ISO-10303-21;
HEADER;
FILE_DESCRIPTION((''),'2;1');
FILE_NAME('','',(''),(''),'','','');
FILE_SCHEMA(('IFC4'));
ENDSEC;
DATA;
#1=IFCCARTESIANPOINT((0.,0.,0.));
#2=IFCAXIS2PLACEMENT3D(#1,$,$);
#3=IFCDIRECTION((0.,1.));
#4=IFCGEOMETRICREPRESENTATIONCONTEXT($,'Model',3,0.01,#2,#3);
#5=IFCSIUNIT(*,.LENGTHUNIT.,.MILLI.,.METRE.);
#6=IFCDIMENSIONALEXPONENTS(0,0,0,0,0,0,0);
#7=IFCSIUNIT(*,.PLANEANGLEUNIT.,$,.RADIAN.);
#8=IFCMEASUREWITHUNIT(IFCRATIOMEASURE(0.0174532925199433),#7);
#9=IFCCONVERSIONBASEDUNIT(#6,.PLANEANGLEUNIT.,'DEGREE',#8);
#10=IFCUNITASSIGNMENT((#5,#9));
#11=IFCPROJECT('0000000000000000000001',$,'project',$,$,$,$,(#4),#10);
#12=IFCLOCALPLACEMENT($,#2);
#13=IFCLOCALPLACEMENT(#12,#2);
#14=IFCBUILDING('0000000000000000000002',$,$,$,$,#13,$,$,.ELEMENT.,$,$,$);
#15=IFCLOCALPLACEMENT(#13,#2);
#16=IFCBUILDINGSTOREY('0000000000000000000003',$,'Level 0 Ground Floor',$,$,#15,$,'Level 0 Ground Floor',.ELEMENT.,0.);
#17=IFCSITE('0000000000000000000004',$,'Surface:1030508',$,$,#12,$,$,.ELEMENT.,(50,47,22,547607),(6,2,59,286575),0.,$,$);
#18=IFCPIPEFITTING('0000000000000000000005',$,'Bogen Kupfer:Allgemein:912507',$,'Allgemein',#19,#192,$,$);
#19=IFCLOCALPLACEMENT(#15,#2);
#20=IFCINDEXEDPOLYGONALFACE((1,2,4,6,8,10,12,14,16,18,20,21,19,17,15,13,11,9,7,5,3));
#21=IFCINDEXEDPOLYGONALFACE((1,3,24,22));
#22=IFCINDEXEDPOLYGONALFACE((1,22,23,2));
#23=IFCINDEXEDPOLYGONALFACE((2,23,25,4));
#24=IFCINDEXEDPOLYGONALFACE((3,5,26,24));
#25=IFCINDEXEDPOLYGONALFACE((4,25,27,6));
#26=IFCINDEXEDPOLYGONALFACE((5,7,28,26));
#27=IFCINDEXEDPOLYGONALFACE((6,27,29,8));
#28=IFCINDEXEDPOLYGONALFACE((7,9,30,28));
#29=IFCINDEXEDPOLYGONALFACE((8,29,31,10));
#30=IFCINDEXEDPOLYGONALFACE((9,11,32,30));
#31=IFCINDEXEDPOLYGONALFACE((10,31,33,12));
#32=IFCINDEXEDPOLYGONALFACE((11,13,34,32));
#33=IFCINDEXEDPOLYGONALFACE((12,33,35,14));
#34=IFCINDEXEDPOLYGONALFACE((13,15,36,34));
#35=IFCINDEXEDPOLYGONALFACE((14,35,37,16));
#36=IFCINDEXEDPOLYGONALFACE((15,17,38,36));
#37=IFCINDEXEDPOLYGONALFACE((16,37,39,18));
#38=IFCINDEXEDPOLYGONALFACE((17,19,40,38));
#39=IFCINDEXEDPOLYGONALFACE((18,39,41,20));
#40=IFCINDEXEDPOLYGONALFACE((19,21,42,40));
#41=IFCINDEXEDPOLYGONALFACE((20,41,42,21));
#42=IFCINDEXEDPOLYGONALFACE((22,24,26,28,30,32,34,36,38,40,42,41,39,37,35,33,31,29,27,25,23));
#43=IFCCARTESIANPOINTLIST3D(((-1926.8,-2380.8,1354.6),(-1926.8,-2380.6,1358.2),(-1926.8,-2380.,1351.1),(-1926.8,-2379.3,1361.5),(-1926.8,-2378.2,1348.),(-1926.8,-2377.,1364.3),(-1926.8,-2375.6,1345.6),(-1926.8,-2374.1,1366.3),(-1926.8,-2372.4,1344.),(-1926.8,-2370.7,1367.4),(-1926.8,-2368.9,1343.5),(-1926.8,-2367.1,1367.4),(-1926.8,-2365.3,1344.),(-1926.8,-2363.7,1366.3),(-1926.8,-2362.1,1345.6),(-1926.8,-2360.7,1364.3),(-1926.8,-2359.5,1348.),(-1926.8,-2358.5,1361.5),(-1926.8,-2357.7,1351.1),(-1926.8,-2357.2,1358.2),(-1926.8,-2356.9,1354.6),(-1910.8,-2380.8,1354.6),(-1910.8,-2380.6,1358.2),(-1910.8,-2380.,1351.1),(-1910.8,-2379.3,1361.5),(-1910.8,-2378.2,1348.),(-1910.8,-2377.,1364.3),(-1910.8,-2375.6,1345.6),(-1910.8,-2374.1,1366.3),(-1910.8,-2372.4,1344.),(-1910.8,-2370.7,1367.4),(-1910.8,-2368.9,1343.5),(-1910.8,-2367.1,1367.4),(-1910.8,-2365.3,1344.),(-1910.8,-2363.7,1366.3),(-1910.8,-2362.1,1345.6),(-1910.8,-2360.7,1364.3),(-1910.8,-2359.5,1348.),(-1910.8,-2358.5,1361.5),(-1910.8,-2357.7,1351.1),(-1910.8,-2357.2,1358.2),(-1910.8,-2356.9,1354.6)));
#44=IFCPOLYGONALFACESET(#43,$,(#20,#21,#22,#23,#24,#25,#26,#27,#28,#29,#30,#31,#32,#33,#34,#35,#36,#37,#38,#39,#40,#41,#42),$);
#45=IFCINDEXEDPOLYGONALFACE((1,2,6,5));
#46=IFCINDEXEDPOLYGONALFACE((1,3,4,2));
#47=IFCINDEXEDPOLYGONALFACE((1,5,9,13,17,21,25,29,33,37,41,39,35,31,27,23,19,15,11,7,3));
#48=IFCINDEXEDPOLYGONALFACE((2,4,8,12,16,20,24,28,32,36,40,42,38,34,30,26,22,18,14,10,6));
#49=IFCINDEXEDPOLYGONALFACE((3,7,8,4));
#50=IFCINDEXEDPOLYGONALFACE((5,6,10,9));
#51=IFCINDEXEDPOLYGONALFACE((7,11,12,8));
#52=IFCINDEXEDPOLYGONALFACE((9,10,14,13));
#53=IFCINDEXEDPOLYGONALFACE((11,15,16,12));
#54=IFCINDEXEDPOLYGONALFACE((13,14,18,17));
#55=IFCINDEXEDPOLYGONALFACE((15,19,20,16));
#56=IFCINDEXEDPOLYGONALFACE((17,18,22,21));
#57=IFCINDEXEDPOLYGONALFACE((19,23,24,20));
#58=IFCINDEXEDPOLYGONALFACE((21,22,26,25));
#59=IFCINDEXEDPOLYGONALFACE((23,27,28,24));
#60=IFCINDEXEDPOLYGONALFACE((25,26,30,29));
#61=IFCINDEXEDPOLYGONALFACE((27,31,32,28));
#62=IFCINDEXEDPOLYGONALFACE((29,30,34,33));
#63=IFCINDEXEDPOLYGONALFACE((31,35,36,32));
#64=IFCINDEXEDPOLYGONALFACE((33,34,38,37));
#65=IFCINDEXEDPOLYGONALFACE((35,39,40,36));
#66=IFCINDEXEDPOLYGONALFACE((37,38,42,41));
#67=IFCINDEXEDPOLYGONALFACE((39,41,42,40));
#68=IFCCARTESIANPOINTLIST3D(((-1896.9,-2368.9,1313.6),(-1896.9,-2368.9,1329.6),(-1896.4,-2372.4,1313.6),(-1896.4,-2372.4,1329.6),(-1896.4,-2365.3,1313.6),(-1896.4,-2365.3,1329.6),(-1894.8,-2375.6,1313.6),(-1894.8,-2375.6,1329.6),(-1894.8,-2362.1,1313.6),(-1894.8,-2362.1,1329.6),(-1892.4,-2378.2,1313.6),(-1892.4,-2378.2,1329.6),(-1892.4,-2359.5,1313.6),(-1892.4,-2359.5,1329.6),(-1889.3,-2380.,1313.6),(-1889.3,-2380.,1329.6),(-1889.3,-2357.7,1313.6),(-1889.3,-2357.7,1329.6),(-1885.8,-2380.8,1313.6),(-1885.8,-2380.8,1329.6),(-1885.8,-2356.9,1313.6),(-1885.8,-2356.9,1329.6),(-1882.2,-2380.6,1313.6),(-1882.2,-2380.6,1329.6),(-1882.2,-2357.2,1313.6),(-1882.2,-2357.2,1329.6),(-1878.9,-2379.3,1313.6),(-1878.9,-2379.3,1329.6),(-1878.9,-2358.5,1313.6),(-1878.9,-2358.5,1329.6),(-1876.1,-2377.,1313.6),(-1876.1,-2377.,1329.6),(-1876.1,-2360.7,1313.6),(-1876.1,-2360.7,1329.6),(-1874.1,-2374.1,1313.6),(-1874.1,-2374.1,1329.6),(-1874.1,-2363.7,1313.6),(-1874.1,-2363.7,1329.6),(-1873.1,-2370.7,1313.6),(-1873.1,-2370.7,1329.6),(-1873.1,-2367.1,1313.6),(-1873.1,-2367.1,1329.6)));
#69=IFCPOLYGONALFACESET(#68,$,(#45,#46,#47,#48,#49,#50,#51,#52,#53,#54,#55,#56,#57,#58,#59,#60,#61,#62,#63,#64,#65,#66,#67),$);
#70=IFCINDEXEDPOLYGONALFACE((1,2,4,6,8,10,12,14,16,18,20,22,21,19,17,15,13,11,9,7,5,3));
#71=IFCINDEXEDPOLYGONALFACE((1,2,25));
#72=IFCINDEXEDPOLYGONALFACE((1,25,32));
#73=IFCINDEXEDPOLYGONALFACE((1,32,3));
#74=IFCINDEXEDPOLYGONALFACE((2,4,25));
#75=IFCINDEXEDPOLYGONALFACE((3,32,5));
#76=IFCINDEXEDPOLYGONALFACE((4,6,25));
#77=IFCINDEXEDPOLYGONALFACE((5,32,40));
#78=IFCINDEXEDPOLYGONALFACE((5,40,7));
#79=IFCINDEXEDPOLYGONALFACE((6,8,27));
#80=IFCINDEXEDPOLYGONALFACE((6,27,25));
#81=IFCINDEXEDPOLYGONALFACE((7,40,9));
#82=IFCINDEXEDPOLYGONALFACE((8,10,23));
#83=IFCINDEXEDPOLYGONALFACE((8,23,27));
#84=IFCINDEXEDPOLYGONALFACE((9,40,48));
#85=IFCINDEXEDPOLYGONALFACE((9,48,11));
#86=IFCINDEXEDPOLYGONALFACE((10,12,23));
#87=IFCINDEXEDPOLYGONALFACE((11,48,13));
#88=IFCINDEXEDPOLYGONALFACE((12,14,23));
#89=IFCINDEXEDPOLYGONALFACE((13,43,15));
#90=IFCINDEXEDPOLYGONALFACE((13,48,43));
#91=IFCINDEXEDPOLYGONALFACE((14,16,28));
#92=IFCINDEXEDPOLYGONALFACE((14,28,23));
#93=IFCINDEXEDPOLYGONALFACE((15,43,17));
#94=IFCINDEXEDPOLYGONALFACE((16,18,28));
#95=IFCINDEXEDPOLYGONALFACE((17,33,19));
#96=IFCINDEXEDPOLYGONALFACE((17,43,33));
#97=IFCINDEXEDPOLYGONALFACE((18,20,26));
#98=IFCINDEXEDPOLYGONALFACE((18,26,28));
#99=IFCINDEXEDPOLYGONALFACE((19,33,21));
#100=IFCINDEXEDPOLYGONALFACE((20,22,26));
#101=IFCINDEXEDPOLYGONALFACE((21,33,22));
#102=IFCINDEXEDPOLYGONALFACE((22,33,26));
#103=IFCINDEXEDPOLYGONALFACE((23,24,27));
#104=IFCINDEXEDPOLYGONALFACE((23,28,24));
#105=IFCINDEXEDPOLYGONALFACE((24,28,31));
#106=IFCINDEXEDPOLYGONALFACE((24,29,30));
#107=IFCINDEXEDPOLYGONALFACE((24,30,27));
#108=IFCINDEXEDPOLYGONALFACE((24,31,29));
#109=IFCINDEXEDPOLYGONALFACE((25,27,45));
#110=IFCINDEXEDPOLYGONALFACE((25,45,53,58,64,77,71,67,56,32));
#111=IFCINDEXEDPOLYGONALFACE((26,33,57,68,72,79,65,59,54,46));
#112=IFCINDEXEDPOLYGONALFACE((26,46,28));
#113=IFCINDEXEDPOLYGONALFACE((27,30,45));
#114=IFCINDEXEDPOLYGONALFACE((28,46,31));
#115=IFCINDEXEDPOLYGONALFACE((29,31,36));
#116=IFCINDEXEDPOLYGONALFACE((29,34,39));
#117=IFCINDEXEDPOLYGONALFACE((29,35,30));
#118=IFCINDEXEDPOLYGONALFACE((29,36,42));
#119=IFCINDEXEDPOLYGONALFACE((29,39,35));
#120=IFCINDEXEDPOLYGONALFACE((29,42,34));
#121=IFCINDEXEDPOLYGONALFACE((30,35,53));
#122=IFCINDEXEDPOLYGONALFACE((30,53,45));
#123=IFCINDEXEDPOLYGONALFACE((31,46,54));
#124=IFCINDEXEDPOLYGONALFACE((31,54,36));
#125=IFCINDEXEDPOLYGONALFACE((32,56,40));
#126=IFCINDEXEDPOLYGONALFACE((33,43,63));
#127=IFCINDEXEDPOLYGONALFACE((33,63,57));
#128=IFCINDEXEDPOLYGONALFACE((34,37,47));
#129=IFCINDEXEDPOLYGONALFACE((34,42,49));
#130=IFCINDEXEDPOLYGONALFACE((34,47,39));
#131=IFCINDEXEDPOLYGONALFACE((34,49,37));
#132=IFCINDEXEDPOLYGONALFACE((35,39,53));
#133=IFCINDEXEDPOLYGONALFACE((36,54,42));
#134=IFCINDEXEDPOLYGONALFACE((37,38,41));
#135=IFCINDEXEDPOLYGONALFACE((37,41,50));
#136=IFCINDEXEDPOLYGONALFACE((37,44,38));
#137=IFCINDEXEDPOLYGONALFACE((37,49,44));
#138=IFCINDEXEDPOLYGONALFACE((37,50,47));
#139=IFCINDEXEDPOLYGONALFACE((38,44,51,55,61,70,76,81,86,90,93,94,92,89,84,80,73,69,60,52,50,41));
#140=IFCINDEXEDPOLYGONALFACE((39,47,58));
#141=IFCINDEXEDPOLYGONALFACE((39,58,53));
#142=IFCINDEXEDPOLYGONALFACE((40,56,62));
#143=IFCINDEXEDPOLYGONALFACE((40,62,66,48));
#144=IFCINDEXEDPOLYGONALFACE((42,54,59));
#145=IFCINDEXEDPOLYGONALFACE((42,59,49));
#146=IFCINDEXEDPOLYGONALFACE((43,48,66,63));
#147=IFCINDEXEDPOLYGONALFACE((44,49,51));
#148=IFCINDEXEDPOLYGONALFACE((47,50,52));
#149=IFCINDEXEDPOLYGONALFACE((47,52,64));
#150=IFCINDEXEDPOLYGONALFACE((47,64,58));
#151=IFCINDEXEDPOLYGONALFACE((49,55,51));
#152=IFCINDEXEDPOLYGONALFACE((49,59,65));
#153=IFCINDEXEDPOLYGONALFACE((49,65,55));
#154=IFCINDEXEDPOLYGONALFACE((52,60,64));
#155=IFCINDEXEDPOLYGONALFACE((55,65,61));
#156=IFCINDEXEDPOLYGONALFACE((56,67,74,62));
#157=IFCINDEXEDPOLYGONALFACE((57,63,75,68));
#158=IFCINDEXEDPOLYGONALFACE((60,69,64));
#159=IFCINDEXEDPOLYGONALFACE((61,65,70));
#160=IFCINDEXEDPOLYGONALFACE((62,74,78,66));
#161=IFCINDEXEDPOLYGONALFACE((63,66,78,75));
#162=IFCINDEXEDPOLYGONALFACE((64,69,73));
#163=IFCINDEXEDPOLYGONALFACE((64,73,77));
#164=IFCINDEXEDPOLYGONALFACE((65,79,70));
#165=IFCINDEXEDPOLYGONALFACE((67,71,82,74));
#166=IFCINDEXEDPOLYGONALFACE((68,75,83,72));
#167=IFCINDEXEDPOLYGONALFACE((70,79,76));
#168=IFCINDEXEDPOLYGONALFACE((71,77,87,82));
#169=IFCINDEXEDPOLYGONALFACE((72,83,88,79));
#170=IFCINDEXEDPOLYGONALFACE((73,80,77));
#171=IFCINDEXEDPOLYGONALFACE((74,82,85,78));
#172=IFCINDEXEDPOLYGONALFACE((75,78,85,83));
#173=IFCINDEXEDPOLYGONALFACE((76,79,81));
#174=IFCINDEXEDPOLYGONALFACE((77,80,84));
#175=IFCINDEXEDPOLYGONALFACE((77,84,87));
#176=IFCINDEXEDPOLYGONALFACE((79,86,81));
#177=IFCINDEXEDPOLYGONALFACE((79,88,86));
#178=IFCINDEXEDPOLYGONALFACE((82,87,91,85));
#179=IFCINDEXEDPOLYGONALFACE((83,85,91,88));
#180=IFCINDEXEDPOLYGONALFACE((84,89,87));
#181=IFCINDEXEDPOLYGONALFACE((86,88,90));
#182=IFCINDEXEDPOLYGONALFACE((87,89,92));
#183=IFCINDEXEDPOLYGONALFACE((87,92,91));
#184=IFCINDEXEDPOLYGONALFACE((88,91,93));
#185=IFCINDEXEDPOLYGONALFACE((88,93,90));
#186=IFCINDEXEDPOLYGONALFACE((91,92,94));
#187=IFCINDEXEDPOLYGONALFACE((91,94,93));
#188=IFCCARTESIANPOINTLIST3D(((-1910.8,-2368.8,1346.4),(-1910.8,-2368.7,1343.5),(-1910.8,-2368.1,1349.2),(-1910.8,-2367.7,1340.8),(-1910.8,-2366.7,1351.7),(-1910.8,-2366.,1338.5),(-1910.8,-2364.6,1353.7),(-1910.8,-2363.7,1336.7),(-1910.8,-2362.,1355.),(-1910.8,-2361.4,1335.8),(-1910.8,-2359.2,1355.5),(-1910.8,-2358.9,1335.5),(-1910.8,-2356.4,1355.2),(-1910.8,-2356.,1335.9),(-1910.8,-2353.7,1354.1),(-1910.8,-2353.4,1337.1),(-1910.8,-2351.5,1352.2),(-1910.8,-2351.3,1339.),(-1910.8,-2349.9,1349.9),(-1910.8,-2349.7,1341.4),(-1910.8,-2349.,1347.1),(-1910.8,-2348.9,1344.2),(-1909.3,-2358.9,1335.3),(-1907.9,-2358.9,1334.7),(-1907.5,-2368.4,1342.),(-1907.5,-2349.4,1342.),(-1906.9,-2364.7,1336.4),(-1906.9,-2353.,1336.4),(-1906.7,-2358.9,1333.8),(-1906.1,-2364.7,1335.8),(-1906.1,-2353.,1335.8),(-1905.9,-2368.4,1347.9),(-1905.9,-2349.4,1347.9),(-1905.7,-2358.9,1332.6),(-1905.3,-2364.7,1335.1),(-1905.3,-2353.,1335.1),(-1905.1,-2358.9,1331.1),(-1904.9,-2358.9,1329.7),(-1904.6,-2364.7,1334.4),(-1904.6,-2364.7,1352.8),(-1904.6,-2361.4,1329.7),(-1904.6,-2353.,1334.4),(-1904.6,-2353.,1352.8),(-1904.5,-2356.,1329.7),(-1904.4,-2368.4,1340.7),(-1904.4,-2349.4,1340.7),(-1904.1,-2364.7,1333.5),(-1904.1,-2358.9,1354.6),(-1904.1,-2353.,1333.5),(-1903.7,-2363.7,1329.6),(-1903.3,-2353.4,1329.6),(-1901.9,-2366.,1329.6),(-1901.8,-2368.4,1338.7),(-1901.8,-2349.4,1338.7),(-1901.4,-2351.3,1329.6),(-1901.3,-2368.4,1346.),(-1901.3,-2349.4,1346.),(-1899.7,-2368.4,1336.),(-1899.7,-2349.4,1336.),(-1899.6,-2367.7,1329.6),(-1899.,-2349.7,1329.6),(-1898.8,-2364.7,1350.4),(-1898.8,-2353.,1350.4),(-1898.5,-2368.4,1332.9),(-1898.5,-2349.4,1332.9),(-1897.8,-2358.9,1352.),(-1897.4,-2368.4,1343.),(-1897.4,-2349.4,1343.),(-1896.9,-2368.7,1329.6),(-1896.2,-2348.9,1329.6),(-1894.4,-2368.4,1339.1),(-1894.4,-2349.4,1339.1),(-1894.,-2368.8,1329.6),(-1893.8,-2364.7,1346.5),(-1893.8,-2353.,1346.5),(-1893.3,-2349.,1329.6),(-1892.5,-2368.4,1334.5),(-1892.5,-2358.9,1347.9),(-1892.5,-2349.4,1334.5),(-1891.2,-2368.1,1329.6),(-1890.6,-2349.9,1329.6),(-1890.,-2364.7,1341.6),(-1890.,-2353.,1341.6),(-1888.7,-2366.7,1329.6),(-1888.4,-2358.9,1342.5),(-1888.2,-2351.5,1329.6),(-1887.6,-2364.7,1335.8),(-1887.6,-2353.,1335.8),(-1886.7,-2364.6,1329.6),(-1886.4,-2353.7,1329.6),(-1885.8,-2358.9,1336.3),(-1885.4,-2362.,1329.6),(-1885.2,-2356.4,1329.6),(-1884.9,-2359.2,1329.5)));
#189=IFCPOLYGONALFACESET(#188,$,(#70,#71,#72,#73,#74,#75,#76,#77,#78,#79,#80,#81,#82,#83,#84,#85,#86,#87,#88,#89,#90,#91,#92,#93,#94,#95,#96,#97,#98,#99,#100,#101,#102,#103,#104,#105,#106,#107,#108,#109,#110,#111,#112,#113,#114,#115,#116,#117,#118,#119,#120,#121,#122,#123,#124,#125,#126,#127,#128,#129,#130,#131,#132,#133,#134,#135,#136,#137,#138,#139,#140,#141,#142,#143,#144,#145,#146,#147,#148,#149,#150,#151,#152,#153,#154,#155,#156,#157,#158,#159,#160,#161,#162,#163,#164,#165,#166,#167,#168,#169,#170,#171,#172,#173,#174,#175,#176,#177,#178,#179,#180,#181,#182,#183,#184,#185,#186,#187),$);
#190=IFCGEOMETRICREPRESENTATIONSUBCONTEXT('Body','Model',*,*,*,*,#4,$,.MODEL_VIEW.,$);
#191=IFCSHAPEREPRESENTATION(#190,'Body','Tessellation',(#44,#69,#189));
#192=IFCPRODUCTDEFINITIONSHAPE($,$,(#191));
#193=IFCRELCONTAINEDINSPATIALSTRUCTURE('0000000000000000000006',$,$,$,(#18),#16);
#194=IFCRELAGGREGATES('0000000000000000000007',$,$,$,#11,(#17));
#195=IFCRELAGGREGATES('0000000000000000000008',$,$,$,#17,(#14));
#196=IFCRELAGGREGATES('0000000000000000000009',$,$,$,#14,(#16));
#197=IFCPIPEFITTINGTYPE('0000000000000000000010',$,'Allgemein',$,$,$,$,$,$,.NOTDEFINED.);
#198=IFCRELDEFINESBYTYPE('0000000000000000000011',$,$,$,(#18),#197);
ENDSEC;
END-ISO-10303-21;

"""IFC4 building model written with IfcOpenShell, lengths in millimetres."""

from ifc_helpers import new_model, entity, si_unit, converted_unit, direction, frame, frame_2d, origin, place, context, subcontext, project, spatial, circle, extrude, source, transform, mapped, type_object, type_shapes, element, save


model = new_model("IFC4")

# Units and contexts
model_context = context("Model", 3, precision=0.01, world=origin(), true_north=direction((0.0, 1.0)))
body_context = subcontext(model_context, "Body", "Model", "MODEL_VIEW")
ifc_project = project(units=[si_unit("LENGTHUNIT", "METRE", prefix="MILLI"), converted_unit("PLANEANGLEUNIT", "DEGREE", entity("IfcRatioMeasure", 0.0174532925199433), si_unit("PLANEANGLEUNIT", "RADIAN"), dimensions=[0, 0, 0, 0, 0, 0, 0])], contexts=[model_context])

# Site, building, storey
site_placement = place(None, origin())
site = spatial("IfcSite", under=ifc_project, at=site_placement, Name="Surface:1030508", CompositionType="ELEMENT", RefLatitude=(50, 47, 22, 547607), RefLongitude=(6, 2, 59, 286575), RefElevation=0.0)
building_placement = place(site_placement, origin())
building = spatial("IfcBuilding", under=site, at=building_placement, CompositionType="ELEMENT")
storey_placement = place(building_placement, origin())
storey = spatial("IfcBuildingStorey", under=building, at=storey_placement, Name="Level 0 Ground Floor", LongName="Level 0 Ground Floor", CompositionType="ELEMENT", Elevation=0.0)

# Pipe fitting
pipe_fitting_type_1 = type_object("IfcPipeFittingType", Name="Allgemein", PredefinedType="NOTDEFINED")
ifc_direction_1 = entity("IfcDirection", [0.0, 0.0, -1.0])
trimmed_curve_1 = entity("IfcTrimmedCurve", entity("IfcCircle", entity("IfcAxis2Placement2D", entity("IfcCartesianPoint", [-15.9, 0.0]), entity("IfcDirection", [0.000089, 1.0])), 15.9), [entity("IfcParameterValue", 270.005081)], [entity("IfcParameterValue", 0.0)], True, "PARAMETER")
shared_shape_1 = source(origin(), body_context, "Body", "SolidModel", [
    extrude(circle(Radius=12.0, at=frame_2d((0.0, 0.0), x_axis=(1.0, 0.0))), frame((0.0, 25.9, 0.0), z_axis=(0.000089, 1.0, 0.0), x_axis=(-1.0, 0.000089, 0.0)), (0.0, 0.0, 1.0), 16.0),
    extrude(circle(Radius=12.0, at=frame_2d((0.0, 0.0), x_axis=(1.0, 0.0))), frame((-41.9, 0.0, 0.0), z_axis=(1.0, 0.0, 0.0), x_axis=(0.0, 1.0, 0.0)), (0.0, 0.0, 1.0), 16.0),
    entity("IfcSurfaceCurveSweptAreaSolid", entity("IfcCircleProfileDef", "AREA", None, entity("IfcAxis2Placement2D", entity("IfcCartesianPoint", [0.0, 10.0]), entity("IfcDirection", [1.0, 0.0])), 10.0), entity("IfcAxis2Placement3D", entity("IfcCartesianPoint", [-10.0, 25.9, 0.0]), ifc_direction_1, entity("IfcDirection", [1.0, -0.000089, 0.0])), trimmed_curve_1, 0.0, 90.0, entity("IfcSurfaceOfLinearExtrusion", entity("IfcArbitraryOpenProfileDef", "CURVE", None, trimmed_curve_1), entity("IfcAxis2Placement3D", entity("IfcCartesianPoint", [0.0, 0.0, -304.8])), ifc_direction_1, 1.0)),
])
type_shapes(pipe_fitting_type_1, [shared_shape_1])
pipe_fitting_1_placement = place(storey_placement, frame((-1884.9, -2368.9, 1355.5), z_axis=(0.0, -1.0, 0.0), x_axis=(0.0, 0.0, 1.0)))
element("IfcPipeFitting", 1, at=pipe_fitting_1_placement, inside=storey, type_object=pipe_fitting_type_1, Name="Bogen Kupfer:Allgemein:912507", ObjectType="Allgemein", context=body_context, shape_type="MappedRepresentation", body=[
    mapped(shared_shape_1, transform((0.0, 0.0, 0.0), scale=1.0)),
])

save(model, "model.ifc")
